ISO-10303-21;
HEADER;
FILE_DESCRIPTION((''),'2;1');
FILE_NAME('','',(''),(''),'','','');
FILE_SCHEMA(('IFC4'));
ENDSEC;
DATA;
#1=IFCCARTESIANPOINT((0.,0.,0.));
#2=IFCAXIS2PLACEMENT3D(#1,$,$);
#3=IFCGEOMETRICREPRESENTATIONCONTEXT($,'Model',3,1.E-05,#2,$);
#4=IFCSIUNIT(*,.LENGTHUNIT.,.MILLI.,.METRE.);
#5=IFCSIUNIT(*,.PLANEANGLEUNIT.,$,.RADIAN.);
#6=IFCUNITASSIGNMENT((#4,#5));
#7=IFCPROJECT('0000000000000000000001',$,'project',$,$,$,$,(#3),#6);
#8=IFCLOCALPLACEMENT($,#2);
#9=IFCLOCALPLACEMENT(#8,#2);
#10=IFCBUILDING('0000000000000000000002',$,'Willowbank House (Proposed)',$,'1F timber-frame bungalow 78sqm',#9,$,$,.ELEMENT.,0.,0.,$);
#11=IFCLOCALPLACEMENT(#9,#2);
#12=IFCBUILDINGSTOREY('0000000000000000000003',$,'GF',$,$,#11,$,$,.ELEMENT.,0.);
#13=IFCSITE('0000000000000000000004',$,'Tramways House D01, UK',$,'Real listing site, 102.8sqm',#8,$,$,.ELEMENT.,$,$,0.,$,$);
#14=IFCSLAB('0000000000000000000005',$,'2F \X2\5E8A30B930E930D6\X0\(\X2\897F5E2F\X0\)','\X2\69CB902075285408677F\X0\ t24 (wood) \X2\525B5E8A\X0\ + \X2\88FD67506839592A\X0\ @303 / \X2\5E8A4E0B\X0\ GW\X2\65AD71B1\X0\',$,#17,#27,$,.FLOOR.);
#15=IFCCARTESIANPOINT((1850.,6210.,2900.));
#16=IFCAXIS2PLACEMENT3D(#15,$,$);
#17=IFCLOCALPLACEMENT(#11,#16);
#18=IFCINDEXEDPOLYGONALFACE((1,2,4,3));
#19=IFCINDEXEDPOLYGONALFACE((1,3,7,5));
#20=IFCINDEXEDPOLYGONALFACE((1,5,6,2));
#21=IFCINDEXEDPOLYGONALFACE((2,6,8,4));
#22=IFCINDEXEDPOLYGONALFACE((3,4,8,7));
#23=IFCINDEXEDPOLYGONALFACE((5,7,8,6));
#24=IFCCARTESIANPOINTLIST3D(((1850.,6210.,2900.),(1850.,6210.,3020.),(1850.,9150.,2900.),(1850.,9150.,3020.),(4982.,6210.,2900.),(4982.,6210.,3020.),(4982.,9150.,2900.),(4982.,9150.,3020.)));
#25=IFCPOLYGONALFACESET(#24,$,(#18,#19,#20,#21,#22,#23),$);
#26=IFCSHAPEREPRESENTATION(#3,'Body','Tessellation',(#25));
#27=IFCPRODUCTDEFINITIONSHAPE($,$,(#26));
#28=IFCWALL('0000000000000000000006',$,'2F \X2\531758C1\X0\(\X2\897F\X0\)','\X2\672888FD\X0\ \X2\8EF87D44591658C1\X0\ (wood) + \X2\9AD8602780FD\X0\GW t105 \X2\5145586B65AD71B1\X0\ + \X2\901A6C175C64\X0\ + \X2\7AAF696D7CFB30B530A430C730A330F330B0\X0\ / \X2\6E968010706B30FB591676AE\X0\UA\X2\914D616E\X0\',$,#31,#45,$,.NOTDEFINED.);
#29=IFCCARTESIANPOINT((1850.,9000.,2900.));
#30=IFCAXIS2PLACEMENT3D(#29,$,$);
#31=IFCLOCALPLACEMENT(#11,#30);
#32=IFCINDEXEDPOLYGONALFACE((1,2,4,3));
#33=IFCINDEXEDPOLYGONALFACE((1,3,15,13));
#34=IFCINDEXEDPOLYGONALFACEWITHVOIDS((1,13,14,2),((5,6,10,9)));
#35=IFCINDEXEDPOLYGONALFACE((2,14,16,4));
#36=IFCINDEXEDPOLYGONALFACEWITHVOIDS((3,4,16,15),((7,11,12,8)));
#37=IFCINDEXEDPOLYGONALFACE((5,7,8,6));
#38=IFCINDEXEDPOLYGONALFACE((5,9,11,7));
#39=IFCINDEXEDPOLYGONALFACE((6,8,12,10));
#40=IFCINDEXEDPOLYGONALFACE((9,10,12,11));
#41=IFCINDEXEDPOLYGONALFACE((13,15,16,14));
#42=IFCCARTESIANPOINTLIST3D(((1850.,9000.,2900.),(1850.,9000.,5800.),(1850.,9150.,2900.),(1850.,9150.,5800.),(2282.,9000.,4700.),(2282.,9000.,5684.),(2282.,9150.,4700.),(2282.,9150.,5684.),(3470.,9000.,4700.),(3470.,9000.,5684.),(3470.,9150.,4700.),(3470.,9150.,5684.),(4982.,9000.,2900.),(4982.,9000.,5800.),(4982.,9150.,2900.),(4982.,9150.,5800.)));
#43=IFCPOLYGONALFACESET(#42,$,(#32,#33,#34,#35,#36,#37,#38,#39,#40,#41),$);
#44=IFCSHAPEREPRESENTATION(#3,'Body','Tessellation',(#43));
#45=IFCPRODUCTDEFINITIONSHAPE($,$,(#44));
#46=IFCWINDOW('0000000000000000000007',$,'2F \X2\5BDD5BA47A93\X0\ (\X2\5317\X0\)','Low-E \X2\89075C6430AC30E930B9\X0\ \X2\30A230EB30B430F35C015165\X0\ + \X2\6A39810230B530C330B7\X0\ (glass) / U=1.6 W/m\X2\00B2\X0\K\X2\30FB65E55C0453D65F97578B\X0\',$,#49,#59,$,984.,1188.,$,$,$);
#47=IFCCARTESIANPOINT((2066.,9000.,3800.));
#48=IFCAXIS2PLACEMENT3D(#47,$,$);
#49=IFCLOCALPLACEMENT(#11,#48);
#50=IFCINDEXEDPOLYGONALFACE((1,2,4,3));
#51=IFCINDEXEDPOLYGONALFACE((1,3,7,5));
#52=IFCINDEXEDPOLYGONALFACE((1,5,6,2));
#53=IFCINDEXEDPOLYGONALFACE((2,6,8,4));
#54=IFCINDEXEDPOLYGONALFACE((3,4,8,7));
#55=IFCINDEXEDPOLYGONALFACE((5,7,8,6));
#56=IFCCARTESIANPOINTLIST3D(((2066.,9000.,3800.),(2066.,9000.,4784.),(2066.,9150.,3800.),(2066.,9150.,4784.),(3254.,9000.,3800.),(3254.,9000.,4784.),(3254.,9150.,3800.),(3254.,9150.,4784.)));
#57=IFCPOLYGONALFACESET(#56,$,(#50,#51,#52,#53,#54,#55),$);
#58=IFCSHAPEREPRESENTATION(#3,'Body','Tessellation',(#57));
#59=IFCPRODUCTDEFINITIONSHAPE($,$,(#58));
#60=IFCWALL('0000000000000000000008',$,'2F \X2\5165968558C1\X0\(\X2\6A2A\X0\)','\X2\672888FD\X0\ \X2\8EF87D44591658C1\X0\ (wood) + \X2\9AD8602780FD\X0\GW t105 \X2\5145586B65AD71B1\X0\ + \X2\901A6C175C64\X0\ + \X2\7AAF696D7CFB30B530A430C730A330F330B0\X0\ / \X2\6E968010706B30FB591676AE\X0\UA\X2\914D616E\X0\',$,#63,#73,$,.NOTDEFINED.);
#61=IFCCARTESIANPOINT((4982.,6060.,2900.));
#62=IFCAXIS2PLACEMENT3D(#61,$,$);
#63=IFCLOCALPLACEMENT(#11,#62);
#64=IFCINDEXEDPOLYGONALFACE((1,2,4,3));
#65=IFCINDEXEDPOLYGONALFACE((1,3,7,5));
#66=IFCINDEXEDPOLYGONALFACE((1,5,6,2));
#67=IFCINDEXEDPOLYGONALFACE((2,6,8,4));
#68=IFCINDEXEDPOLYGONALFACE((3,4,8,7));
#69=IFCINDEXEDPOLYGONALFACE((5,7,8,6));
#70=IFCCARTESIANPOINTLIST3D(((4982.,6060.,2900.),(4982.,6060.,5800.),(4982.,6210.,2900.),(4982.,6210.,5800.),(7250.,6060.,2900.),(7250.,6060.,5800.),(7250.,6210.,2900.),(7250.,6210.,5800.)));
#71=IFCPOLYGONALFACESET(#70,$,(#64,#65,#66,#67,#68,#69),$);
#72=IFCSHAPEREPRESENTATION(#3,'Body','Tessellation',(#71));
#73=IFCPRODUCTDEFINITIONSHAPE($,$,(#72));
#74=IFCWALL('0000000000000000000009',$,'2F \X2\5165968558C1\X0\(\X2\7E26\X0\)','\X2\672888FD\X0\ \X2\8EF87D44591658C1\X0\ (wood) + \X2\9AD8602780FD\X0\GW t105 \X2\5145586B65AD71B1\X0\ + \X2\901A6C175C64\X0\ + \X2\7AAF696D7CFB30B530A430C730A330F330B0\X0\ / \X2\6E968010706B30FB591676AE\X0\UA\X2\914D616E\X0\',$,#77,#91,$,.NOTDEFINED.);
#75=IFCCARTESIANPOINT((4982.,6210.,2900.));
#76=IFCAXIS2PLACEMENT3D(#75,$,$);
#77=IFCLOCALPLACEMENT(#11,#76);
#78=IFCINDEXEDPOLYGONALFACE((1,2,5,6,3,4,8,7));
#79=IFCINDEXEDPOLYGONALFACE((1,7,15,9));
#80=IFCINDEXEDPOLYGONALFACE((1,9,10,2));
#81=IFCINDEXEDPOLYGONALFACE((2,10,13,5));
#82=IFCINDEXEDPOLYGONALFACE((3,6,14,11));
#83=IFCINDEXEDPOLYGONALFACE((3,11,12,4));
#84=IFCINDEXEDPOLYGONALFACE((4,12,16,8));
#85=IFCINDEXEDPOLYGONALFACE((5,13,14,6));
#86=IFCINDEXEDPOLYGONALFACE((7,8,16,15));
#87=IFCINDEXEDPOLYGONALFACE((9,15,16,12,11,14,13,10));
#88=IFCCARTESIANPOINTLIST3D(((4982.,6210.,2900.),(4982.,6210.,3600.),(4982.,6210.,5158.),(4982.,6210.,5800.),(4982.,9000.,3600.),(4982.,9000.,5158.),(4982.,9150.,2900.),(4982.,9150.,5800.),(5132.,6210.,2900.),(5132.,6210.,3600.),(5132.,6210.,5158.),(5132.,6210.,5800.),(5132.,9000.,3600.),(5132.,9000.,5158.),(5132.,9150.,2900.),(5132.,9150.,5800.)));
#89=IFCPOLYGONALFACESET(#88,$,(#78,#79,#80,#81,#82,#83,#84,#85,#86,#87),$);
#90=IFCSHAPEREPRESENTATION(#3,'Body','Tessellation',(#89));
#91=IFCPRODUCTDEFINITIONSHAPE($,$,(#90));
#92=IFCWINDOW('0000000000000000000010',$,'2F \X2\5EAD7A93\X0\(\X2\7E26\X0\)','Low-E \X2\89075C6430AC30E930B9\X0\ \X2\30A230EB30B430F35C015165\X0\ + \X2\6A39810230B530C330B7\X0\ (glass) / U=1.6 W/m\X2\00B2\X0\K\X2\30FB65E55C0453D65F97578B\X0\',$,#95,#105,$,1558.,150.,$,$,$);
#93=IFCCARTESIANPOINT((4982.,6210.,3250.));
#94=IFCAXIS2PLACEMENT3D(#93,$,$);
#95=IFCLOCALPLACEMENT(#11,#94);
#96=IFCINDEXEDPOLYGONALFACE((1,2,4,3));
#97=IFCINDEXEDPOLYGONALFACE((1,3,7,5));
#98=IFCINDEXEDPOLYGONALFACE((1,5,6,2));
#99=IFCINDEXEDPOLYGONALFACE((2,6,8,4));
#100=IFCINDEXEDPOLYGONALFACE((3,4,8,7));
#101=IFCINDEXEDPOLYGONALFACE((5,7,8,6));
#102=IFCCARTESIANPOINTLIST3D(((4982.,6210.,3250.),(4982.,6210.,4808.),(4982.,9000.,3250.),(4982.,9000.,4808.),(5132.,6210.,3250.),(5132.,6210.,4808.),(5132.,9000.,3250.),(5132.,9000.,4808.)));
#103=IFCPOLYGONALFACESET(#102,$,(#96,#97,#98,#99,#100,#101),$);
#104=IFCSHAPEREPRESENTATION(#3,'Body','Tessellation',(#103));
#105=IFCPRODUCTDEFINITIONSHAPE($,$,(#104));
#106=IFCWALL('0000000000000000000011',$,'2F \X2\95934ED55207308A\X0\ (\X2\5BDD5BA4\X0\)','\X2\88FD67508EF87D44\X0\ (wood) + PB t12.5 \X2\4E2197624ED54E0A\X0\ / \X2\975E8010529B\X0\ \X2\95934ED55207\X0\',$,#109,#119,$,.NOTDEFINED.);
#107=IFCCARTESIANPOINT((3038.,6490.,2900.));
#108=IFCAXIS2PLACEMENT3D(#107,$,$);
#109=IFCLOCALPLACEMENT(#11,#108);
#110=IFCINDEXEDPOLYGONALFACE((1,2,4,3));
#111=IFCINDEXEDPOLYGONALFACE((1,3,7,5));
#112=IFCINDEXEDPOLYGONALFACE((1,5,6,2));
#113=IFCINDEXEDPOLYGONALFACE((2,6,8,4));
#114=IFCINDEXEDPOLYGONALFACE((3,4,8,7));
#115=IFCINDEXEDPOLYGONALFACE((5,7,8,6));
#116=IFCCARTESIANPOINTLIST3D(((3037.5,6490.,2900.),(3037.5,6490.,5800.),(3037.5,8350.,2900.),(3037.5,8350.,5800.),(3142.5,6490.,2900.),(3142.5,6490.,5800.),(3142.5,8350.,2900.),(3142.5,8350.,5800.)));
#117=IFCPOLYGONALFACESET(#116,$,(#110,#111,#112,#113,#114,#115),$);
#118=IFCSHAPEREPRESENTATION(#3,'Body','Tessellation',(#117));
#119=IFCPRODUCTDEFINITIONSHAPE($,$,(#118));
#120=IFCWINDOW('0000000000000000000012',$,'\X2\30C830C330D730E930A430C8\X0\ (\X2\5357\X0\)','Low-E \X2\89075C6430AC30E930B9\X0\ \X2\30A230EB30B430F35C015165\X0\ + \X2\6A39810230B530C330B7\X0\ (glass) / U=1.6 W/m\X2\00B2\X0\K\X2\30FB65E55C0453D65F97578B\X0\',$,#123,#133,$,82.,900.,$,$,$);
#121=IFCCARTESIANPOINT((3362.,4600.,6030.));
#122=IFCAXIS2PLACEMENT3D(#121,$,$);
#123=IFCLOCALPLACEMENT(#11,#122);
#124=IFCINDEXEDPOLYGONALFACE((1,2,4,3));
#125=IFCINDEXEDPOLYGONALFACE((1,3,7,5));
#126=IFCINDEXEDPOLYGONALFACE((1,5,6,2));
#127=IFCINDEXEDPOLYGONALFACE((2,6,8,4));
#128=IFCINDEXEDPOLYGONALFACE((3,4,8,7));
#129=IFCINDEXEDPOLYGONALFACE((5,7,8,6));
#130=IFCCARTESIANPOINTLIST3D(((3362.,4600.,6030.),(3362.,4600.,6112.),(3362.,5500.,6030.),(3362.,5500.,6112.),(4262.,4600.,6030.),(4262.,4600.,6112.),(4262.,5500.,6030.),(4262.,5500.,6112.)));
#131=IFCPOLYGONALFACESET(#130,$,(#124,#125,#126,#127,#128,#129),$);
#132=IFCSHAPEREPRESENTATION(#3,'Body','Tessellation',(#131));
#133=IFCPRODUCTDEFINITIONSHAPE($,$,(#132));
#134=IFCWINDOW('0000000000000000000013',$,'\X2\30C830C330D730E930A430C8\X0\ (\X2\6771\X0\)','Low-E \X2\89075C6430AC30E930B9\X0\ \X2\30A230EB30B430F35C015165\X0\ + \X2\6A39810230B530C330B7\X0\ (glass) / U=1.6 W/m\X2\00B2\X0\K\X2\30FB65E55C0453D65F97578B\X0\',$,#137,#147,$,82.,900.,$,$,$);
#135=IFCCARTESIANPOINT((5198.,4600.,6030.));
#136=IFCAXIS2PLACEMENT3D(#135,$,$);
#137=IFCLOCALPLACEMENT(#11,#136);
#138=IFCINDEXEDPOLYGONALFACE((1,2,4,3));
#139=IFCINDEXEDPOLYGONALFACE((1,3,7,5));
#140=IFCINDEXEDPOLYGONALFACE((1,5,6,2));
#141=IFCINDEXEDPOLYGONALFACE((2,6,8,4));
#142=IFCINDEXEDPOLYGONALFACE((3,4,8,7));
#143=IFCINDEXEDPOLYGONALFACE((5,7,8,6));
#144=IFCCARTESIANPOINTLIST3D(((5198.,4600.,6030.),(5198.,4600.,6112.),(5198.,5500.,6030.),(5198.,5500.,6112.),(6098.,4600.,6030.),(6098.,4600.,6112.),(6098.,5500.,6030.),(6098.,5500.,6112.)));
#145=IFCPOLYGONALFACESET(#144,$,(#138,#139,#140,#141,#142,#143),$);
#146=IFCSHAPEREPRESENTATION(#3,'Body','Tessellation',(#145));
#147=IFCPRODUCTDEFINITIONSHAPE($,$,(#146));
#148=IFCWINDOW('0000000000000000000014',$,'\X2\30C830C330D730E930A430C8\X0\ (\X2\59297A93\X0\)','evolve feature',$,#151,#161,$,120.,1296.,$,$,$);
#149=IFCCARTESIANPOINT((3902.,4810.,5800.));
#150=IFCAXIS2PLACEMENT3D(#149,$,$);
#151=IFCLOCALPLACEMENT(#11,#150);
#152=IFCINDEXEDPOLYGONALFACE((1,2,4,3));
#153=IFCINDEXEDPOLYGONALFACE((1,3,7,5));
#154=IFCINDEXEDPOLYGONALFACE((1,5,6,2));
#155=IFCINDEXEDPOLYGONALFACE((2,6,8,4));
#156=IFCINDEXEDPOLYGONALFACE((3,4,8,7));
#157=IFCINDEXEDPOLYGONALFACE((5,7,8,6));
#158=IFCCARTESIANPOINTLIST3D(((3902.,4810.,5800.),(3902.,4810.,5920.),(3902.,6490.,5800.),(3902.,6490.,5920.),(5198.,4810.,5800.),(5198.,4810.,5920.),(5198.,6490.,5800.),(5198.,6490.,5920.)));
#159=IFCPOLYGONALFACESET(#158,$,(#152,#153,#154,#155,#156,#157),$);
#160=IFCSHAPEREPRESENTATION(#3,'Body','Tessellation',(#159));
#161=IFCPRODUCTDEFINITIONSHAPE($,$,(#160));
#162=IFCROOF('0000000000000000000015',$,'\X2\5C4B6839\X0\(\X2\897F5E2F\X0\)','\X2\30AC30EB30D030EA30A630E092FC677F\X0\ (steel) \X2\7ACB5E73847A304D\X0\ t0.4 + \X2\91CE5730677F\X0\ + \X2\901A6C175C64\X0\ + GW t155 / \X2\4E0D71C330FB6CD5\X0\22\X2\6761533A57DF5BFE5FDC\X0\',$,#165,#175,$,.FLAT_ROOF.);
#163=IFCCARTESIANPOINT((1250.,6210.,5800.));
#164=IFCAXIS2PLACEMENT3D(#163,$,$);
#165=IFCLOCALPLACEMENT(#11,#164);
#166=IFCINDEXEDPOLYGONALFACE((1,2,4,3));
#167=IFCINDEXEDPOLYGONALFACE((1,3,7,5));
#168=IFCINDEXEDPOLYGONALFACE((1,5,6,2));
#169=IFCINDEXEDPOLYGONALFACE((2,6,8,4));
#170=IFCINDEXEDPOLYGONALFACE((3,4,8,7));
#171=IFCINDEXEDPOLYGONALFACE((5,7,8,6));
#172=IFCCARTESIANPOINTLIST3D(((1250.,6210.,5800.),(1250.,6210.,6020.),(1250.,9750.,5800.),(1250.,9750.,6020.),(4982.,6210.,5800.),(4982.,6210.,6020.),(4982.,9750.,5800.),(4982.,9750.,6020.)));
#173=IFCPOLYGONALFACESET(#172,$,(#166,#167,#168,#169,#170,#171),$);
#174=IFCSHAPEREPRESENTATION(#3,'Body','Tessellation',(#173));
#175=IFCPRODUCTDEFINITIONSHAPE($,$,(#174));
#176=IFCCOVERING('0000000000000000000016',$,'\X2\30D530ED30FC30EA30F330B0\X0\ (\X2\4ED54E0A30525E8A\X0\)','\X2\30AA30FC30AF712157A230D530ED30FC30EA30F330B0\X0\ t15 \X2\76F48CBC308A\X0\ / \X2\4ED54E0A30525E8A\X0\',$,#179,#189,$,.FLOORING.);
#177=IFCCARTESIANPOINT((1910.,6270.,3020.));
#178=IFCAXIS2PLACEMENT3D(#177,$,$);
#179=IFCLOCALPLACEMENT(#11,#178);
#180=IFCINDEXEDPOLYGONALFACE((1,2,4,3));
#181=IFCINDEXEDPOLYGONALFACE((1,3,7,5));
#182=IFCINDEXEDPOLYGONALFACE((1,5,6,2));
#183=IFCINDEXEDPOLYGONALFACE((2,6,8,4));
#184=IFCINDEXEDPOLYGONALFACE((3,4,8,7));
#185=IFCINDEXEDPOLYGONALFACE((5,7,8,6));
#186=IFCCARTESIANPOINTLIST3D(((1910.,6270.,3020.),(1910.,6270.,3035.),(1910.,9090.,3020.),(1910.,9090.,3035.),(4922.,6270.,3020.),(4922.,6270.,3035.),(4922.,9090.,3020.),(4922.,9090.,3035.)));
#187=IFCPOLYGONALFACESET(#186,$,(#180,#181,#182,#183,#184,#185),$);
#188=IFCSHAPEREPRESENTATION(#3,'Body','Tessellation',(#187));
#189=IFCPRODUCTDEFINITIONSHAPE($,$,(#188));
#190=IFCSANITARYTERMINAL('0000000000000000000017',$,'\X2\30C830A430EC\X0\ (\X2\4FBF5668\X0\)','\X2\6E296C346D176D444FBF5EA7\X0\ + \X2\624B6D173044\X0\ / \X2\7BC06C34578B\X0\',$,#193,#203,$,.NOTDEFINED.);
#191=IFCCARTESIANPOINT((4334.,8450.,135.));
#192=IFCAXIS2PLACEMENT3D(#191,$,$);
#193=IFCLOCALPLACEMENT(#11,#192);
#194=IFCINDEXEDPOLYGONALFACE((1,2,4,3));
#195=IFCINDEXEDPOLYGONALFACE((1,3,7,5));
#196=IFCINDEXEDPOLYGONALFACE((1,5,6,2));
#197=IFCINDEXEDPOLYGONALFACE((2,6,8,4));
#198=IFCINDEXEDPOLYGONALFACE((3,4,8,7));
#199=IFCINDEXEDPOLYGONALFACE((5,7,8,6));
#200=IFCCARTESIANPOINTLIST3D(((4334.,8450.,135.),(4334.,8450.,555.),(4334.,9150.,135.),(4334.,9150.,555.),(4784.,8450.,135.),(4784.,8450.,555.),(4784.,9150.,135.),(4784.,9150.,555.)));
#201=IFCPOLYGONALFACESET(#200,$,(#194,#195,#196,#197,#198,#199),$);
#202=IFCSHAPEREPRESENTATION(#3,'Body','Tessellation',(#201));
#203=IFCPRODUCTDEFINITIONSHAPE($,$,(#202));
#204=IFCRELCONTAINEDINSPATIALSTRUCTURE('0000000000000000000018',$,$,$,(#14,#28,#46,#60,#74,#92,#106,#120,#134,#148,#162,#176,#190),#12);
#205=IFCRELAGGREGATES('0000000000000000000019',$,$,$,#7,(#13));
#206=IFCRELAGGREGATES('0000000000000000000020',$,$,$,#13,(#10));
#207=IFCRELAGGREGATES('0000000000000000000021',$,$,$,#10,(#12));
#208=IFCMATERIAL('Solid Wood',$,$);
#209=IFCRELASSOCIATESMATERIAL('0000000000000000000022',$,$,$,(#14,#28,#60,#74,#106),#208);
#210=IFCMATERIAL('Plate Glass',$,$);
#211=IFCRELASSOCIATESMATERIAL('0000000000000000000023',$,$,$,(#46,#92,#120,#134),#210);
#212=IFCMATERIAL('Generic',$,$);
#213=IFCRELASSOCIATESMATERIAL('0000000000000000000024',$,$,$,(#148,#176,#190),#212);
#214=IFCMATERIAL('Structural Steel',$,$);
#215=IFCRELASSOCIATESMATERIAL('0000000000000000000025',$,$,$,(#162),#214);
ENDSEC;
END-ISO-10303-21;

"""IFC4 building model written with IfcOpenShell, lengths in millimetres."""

from ifc_helpers import new_model, si_unit, frame, frame_2d, origin, place, context, project, spatial, rectangle, extrude, material, element, fill, save


model = new_model("IFC4")

# Units and contexts
model_context = context("Model", 3, precision=1e-05, world=origin())
ifc_project = project(units=[si_unit("LENGTHUNIT", "METRE", prefix="MILLI"), si_unit("PLANEANGLEUNIT", "RADIAN")], contexts=[model_context])

# Site, building, storey
site_placement = place(None, origin())
site = spatial("IfcSite", under=ifc_project, at=site_placement, Name="Tramways House D01, UK", ObjectType="Real listing site, 102.8sqm", CompositionType="ELEMENT", RefElevation=0.0)
building_placement = place(site_placement, origin())
building = spatial("IfcBuilding", under=site, at=building_placement, Name="Willowbank House (Proposed)", ObjectType="1F timber-frame bungalow 78sqm", CompositionType="ELEMENT", ElevationOfRefHeight=0.0, ElevationOfTerrain=0.0)
storey_placement = place(building_placement, origin())
storey = spatial("IfcBuildingStorey", under=building, at=storey_placement, Name="GF", CompositionType="ELEMENT", Elevation=0.0)

# Slab
ifc_material_1 = material(Name="Solid Wood")
slab_placement = place(storey_placement, frame((1850.0, 6210.0, 2900.0)))
element("IfcSlab", 1, at=slab_placement, inside=storey, material=ifc_material_1, Name="2F 床スラブ(西帯)", Description="構造用合板 t24 (wood) 剛床 + 製材根太 @303 / 床下 GW断熱", PredefinedType="FLOOR", context=model_context, shape_type="SweptSolid", body=[
    extrude(rectangle(XDim=3132.0, YDim=2940.0, at=frame_2d((1566.0, 1470.0))), frame((1850.0, 6210.0, 2900.0)), (0.0, 0.0, 1.0), 120.0),
])

# Wall, opening, window
wall_1_placement = place(storey_placement, frame((1850.0, 9000.0, 2900.0)))
wall_1 = element("IfcWall", 2, at=wall_1_placement, inside=storey, material=ifc_material_1, Name="2F 北壁(西)", Description="木製 軸組外壁 (wood) + 高性能GW t105 充填断熱 + 通気層 + 窯業系サイディング / 準耐火・外皮UA配慮", PredefinedType="NOTDEFINED", context=model_context, shape_type="SweptSolid", body=[
    extrude(rectangle(XDim=3132.0, YDim=150.0, at=frame_2d((1566.0, 75.0))), frame((1850.0, 9000.0, 2900.0)), (0.0, 0.0, 1.0), 2900.0),
])
opening_1_placement = place(storey_placement, frame((2066.0, 9000.0, 3800.0)))
opening_1 = element("IfcOpeningElement", 3, at=opening_1_placement, cuts=wall_1, PredefinedType="NOTDEFINED", context=model_context, shape_type="SweptSolid", body=[
    extrude(rectangle(XDim=1188.0, YDim=150.0, at=frame_2d((594.0, 75.0))), frame((2066.0, 9000.0, 3800.0)), (0.0, 0.0, 1.0), 984.0),
])
ifc_material_2 = material(Name="Plate Glass")
window_1_placement = place(storey_placement, frame((2066.0, 9000.0, 3800.0)))
window_1 = element("IfcWindow", 4, at=window_1_placement, inside=storey, material=ifc_material_2, Name="2F 寝室窓 (北)", Description="Low-E 複層ガラス アルゴン封入 + 樹脂サッシ (glass) / U=1.6 W/m²K・日射取得型", OverallHeight=984.0, OverallWidth=1188.0, context=model_context, shape_type="SweptSolid", body=[
    extrude(rectangle(XDim=1188.0, YDim=150.0, at=frame_2d((594.0, 75.0))), frame((2066.0, 9000.0, 3800.0)), (0.0, 0.0, 1.0), 984.0),
])
fill(opening_1, window_1)

# Wall
wall_2_placement = place(storey_placement, frame((4982.0, 6060.0, 2900.0)))
element("IfcWall", 5, at=wall_2_placement, inside=storey, material=ifc_material_1, Name="2F 入隅壁(横)", Description="木製 軸組外壁 (wood) + 高性能GW t105 充填断熱 + 通気層 + 窯業系サイディング / 準耐火・外皮UA配慮", PredefinedType="NOTDEFINED", context=model_context, shape_type="SweptSolid", body=[
    extrude(rectangle(XDim=2268.0, YDim=150.0, at=frame_2d((1134.0, 75.0))), frame((4982.0, 6060.0, 2900.0)), (0.0, 0.0, 1.0), 2900.0),
])

# Wall, opening, window
wall_3_placement = place(storey_placement, frame((4982.0, 6210.0, 2900.0)))
wall_3 = element("IfcWall", 6, at=wall_3_placement, inside=storey, material=ifc_material_1, Name="2F 入隅壁(縦)", Description="木製 軸組外壁 (wood) + 高性能GW t105 充填断熱 + 通気層 + 窯業系サイディング / 準耐火・外皮UA配慮", PredefinedType="NOTDEFINED", context=model_context, shape_type="SweptSolid", body=[
    extrude(rectangle(XDim=150.0, YDim=2940.0, at=frame_2d((75.0, 1470.0))), frame((4982.0, 6210.0, 2900.0)), (0.0, 0.0, 1.0), 2900.0),
])
opening_2_placement = place(storey_placement, frame((4982.0, 6210.0, 3250.0)))
opening_2 = element("IfcOpeningElement", 7, at=opening_2_placement, cuts=wall_3, PredefinedType="NOTDEFINED", context=model_context, shape_type="SweptSolid", body=[
    extrude(rectangle(XDim=150.0, YDim=2790.0, at=frame_2d((75.0, 1395.0))), frame((4982.0, 6210.0, 3250.0)), (0.0, 0.0, 1.0), 1558.0),
])
window_2_placement = place(storey_placement, frame((4982.0, 6210.0, 3250.0)))
window_2 = element("IfcWindow", 8, at=window_2_placement, inside=storey, material=ifc_material_2, Name="2F 庭窓(縦)", Description="Low-E 複層ガラス アルゴン封入 + 樹脂サッシ (glass) / U=1.6 W/m²K・日射取得型", OverallHeight=1558.0, OverallWidth=150.0, context=model_context, shape_type="SweptSolid", body=[
    extrude(rectangle(XDim=150.0, YDim=2790.0, at=frame_2d((75.0, 1395.0))), frame((4982.0, 6210.0, 3250.0)), (0.0, 0.0, 1.0), 1558.0),
])
fill(opening_2, window_2)

# Wall
wall_4_placement = place(storey_placement, frame((3038.0, 6490.0, 2900.0)))
element("IfcWall", 9, at=wall_4_placement, inside=storey, material=ifc_material_1, Name="2F 間仕切り (寝室)", Description="製材軸組 (wood) + PB t12.5 両面仕上 / 非耐力 間仕切", PredefinedType="NOTDEFINED", context=model_context, shape_type="SweptSolid", body=[
    extrude(rectangle(XDim=105.0, YDim=1860.0, at=frame_2d((52.0, 930.0))), frame((3038.0, 6490.0, 2900.0)), (0.0, 0.0, 1.0), 2900.0),
])

# Windows
window_3_placement = place(storey_placement, frame((3362.0, 4600.0, 6030.0)))
element("IfcWindow", 10, at=window_3_placement, inside=storey, material=ifc_material_2, Name="トップライト (南)", Description="Low-E 複層ガラス アルゴン封入 + 樹脂サッシ (glass) / U=1.6 W/m²K・日射取得型", OverallHeight=82.0, OverallWidth=900.0, context=model_context, shape_type="SweptSolid", body=[
    extrude(rectangle(XDim=900.0, YDim=900.0, at=frame_2d((450.0, 450.0))), frame((3362.0, 4600.0, 6030.0)), (0.0, 0.0, 1.0), 82.0),
])
window_4_placement = place(storey_placement, frame((5198.0, 4600.0, 6030.0)))
element("IfcWindow", 11, at=window_4_placement, inside=storey, material=ifc_material_2, Name="トップライト (東)", Description="Low-E 複層ガラス アルゴン封入 + 樹脂サッシ (glass) / U=1.6 W/m²K・日射取得型", OverallHeight=82.0, OverallWidth=900.0, context=model_context, shape_type="SweptSolid", body=[
    extrude(rectangle(XDim=900.0, YDim=900.0, at=frame_2d((450.0, 450.0))), frame((5198.0, 4600.0, 6030.0)), (0.0, 0.0, 1.0), 82.0),
])
ifc_material_3 = material(Name="Generic")
window_5_placement = place(storey_placement, frame((3902.0, 4810.0, 5800.0)))
element("IfcWindow", 12, at=window_5_placement, inside=storey, material=ifc_material_3, Name="トップライト (天窓)", Description="evolve feature", OverallHeight=120.0, OverallWidth=1296.0, context=model_context, shape_type="SweptSolid", body=[
    extrude(rectangle(XDim=1296.0, YDim=1680.0, at=frame_2d((648.0, 840.0))), frame((3902.0, 4810.0, 5800.0)), (0.0, 0.0, 1.0), 120.0),
])

# Roof
ifc_material_4 = material(Name="Structural Steel")
for number, where, name in (
    (13, (1250.0, 6210.0, 5800.0), "屋根(西帯)"),
):
    element("IfcRoof", number, at=place(storey_placement, frame(where)), inside=storey, material=ifc_material_4, Name=name, Description="ガルバリウム鋼板 (steel) 立平葺き t0.4 + 野地板 + 通気層 + GW t155 / 不燃・法22条区域対応", PredefinedType="FLAT_ROOF", context=model_context, shape_type="SweptSolid", body=[
        extrude(rectangle(XDim=3732.0, YDim=3540.0, at=frame_2d((1866.0, 1770.0))), frame((1250.0, 6210.0, 5800.0)), (0.0, 0.0, 1.0), 220.0),
    ])

# Covering
covering_placement = place(storey_placement, frame((1910.0, 6270.0, 3020.0)))
element("IfcCovering", 14, at=covering_placement, inside=storey, material=ifc_material_3, Name="フローリング (仕上げ床)", Description="オーク無垢フローリング t15 直貼り / 仕上げ床", PredefinedType="FLOORING", context=model_context, shape_type="SweptSolid", body=[
    extrude(rectangle(XDim=3012.0, YDim=2820.0, at=frame_2d((1506.0, 1410.0))), frame((1910.0, 6270.0, 3020.0)), (0.0, 0.0, 1.0), 15.0),
])

# Sanitary terminal
sanitary_terminal_placement = place(storey_placement, frame((4334.0, 8450.0, 135.0)))
element("IfcSanitaryTerminal", 15, at=sanitary_terminal_placement, inside=storey, material=ifc_material_3, Name="トイレ (便器)", Description="温水洗浄便座 + 手洗い / 節水型", PredefinedType="NOTDEFINED", context=model_context, shape_type="SweptSolid", body=[
    extrude(rectangle(XDim=450.0, YDim=700.0, at=frame_2d((225.0, 350.0))), frame((4334.0, 8450.0, 135.0)), (0.0, 0.0, 1.0), 420.0),
])

save(model, "model.ifc")
